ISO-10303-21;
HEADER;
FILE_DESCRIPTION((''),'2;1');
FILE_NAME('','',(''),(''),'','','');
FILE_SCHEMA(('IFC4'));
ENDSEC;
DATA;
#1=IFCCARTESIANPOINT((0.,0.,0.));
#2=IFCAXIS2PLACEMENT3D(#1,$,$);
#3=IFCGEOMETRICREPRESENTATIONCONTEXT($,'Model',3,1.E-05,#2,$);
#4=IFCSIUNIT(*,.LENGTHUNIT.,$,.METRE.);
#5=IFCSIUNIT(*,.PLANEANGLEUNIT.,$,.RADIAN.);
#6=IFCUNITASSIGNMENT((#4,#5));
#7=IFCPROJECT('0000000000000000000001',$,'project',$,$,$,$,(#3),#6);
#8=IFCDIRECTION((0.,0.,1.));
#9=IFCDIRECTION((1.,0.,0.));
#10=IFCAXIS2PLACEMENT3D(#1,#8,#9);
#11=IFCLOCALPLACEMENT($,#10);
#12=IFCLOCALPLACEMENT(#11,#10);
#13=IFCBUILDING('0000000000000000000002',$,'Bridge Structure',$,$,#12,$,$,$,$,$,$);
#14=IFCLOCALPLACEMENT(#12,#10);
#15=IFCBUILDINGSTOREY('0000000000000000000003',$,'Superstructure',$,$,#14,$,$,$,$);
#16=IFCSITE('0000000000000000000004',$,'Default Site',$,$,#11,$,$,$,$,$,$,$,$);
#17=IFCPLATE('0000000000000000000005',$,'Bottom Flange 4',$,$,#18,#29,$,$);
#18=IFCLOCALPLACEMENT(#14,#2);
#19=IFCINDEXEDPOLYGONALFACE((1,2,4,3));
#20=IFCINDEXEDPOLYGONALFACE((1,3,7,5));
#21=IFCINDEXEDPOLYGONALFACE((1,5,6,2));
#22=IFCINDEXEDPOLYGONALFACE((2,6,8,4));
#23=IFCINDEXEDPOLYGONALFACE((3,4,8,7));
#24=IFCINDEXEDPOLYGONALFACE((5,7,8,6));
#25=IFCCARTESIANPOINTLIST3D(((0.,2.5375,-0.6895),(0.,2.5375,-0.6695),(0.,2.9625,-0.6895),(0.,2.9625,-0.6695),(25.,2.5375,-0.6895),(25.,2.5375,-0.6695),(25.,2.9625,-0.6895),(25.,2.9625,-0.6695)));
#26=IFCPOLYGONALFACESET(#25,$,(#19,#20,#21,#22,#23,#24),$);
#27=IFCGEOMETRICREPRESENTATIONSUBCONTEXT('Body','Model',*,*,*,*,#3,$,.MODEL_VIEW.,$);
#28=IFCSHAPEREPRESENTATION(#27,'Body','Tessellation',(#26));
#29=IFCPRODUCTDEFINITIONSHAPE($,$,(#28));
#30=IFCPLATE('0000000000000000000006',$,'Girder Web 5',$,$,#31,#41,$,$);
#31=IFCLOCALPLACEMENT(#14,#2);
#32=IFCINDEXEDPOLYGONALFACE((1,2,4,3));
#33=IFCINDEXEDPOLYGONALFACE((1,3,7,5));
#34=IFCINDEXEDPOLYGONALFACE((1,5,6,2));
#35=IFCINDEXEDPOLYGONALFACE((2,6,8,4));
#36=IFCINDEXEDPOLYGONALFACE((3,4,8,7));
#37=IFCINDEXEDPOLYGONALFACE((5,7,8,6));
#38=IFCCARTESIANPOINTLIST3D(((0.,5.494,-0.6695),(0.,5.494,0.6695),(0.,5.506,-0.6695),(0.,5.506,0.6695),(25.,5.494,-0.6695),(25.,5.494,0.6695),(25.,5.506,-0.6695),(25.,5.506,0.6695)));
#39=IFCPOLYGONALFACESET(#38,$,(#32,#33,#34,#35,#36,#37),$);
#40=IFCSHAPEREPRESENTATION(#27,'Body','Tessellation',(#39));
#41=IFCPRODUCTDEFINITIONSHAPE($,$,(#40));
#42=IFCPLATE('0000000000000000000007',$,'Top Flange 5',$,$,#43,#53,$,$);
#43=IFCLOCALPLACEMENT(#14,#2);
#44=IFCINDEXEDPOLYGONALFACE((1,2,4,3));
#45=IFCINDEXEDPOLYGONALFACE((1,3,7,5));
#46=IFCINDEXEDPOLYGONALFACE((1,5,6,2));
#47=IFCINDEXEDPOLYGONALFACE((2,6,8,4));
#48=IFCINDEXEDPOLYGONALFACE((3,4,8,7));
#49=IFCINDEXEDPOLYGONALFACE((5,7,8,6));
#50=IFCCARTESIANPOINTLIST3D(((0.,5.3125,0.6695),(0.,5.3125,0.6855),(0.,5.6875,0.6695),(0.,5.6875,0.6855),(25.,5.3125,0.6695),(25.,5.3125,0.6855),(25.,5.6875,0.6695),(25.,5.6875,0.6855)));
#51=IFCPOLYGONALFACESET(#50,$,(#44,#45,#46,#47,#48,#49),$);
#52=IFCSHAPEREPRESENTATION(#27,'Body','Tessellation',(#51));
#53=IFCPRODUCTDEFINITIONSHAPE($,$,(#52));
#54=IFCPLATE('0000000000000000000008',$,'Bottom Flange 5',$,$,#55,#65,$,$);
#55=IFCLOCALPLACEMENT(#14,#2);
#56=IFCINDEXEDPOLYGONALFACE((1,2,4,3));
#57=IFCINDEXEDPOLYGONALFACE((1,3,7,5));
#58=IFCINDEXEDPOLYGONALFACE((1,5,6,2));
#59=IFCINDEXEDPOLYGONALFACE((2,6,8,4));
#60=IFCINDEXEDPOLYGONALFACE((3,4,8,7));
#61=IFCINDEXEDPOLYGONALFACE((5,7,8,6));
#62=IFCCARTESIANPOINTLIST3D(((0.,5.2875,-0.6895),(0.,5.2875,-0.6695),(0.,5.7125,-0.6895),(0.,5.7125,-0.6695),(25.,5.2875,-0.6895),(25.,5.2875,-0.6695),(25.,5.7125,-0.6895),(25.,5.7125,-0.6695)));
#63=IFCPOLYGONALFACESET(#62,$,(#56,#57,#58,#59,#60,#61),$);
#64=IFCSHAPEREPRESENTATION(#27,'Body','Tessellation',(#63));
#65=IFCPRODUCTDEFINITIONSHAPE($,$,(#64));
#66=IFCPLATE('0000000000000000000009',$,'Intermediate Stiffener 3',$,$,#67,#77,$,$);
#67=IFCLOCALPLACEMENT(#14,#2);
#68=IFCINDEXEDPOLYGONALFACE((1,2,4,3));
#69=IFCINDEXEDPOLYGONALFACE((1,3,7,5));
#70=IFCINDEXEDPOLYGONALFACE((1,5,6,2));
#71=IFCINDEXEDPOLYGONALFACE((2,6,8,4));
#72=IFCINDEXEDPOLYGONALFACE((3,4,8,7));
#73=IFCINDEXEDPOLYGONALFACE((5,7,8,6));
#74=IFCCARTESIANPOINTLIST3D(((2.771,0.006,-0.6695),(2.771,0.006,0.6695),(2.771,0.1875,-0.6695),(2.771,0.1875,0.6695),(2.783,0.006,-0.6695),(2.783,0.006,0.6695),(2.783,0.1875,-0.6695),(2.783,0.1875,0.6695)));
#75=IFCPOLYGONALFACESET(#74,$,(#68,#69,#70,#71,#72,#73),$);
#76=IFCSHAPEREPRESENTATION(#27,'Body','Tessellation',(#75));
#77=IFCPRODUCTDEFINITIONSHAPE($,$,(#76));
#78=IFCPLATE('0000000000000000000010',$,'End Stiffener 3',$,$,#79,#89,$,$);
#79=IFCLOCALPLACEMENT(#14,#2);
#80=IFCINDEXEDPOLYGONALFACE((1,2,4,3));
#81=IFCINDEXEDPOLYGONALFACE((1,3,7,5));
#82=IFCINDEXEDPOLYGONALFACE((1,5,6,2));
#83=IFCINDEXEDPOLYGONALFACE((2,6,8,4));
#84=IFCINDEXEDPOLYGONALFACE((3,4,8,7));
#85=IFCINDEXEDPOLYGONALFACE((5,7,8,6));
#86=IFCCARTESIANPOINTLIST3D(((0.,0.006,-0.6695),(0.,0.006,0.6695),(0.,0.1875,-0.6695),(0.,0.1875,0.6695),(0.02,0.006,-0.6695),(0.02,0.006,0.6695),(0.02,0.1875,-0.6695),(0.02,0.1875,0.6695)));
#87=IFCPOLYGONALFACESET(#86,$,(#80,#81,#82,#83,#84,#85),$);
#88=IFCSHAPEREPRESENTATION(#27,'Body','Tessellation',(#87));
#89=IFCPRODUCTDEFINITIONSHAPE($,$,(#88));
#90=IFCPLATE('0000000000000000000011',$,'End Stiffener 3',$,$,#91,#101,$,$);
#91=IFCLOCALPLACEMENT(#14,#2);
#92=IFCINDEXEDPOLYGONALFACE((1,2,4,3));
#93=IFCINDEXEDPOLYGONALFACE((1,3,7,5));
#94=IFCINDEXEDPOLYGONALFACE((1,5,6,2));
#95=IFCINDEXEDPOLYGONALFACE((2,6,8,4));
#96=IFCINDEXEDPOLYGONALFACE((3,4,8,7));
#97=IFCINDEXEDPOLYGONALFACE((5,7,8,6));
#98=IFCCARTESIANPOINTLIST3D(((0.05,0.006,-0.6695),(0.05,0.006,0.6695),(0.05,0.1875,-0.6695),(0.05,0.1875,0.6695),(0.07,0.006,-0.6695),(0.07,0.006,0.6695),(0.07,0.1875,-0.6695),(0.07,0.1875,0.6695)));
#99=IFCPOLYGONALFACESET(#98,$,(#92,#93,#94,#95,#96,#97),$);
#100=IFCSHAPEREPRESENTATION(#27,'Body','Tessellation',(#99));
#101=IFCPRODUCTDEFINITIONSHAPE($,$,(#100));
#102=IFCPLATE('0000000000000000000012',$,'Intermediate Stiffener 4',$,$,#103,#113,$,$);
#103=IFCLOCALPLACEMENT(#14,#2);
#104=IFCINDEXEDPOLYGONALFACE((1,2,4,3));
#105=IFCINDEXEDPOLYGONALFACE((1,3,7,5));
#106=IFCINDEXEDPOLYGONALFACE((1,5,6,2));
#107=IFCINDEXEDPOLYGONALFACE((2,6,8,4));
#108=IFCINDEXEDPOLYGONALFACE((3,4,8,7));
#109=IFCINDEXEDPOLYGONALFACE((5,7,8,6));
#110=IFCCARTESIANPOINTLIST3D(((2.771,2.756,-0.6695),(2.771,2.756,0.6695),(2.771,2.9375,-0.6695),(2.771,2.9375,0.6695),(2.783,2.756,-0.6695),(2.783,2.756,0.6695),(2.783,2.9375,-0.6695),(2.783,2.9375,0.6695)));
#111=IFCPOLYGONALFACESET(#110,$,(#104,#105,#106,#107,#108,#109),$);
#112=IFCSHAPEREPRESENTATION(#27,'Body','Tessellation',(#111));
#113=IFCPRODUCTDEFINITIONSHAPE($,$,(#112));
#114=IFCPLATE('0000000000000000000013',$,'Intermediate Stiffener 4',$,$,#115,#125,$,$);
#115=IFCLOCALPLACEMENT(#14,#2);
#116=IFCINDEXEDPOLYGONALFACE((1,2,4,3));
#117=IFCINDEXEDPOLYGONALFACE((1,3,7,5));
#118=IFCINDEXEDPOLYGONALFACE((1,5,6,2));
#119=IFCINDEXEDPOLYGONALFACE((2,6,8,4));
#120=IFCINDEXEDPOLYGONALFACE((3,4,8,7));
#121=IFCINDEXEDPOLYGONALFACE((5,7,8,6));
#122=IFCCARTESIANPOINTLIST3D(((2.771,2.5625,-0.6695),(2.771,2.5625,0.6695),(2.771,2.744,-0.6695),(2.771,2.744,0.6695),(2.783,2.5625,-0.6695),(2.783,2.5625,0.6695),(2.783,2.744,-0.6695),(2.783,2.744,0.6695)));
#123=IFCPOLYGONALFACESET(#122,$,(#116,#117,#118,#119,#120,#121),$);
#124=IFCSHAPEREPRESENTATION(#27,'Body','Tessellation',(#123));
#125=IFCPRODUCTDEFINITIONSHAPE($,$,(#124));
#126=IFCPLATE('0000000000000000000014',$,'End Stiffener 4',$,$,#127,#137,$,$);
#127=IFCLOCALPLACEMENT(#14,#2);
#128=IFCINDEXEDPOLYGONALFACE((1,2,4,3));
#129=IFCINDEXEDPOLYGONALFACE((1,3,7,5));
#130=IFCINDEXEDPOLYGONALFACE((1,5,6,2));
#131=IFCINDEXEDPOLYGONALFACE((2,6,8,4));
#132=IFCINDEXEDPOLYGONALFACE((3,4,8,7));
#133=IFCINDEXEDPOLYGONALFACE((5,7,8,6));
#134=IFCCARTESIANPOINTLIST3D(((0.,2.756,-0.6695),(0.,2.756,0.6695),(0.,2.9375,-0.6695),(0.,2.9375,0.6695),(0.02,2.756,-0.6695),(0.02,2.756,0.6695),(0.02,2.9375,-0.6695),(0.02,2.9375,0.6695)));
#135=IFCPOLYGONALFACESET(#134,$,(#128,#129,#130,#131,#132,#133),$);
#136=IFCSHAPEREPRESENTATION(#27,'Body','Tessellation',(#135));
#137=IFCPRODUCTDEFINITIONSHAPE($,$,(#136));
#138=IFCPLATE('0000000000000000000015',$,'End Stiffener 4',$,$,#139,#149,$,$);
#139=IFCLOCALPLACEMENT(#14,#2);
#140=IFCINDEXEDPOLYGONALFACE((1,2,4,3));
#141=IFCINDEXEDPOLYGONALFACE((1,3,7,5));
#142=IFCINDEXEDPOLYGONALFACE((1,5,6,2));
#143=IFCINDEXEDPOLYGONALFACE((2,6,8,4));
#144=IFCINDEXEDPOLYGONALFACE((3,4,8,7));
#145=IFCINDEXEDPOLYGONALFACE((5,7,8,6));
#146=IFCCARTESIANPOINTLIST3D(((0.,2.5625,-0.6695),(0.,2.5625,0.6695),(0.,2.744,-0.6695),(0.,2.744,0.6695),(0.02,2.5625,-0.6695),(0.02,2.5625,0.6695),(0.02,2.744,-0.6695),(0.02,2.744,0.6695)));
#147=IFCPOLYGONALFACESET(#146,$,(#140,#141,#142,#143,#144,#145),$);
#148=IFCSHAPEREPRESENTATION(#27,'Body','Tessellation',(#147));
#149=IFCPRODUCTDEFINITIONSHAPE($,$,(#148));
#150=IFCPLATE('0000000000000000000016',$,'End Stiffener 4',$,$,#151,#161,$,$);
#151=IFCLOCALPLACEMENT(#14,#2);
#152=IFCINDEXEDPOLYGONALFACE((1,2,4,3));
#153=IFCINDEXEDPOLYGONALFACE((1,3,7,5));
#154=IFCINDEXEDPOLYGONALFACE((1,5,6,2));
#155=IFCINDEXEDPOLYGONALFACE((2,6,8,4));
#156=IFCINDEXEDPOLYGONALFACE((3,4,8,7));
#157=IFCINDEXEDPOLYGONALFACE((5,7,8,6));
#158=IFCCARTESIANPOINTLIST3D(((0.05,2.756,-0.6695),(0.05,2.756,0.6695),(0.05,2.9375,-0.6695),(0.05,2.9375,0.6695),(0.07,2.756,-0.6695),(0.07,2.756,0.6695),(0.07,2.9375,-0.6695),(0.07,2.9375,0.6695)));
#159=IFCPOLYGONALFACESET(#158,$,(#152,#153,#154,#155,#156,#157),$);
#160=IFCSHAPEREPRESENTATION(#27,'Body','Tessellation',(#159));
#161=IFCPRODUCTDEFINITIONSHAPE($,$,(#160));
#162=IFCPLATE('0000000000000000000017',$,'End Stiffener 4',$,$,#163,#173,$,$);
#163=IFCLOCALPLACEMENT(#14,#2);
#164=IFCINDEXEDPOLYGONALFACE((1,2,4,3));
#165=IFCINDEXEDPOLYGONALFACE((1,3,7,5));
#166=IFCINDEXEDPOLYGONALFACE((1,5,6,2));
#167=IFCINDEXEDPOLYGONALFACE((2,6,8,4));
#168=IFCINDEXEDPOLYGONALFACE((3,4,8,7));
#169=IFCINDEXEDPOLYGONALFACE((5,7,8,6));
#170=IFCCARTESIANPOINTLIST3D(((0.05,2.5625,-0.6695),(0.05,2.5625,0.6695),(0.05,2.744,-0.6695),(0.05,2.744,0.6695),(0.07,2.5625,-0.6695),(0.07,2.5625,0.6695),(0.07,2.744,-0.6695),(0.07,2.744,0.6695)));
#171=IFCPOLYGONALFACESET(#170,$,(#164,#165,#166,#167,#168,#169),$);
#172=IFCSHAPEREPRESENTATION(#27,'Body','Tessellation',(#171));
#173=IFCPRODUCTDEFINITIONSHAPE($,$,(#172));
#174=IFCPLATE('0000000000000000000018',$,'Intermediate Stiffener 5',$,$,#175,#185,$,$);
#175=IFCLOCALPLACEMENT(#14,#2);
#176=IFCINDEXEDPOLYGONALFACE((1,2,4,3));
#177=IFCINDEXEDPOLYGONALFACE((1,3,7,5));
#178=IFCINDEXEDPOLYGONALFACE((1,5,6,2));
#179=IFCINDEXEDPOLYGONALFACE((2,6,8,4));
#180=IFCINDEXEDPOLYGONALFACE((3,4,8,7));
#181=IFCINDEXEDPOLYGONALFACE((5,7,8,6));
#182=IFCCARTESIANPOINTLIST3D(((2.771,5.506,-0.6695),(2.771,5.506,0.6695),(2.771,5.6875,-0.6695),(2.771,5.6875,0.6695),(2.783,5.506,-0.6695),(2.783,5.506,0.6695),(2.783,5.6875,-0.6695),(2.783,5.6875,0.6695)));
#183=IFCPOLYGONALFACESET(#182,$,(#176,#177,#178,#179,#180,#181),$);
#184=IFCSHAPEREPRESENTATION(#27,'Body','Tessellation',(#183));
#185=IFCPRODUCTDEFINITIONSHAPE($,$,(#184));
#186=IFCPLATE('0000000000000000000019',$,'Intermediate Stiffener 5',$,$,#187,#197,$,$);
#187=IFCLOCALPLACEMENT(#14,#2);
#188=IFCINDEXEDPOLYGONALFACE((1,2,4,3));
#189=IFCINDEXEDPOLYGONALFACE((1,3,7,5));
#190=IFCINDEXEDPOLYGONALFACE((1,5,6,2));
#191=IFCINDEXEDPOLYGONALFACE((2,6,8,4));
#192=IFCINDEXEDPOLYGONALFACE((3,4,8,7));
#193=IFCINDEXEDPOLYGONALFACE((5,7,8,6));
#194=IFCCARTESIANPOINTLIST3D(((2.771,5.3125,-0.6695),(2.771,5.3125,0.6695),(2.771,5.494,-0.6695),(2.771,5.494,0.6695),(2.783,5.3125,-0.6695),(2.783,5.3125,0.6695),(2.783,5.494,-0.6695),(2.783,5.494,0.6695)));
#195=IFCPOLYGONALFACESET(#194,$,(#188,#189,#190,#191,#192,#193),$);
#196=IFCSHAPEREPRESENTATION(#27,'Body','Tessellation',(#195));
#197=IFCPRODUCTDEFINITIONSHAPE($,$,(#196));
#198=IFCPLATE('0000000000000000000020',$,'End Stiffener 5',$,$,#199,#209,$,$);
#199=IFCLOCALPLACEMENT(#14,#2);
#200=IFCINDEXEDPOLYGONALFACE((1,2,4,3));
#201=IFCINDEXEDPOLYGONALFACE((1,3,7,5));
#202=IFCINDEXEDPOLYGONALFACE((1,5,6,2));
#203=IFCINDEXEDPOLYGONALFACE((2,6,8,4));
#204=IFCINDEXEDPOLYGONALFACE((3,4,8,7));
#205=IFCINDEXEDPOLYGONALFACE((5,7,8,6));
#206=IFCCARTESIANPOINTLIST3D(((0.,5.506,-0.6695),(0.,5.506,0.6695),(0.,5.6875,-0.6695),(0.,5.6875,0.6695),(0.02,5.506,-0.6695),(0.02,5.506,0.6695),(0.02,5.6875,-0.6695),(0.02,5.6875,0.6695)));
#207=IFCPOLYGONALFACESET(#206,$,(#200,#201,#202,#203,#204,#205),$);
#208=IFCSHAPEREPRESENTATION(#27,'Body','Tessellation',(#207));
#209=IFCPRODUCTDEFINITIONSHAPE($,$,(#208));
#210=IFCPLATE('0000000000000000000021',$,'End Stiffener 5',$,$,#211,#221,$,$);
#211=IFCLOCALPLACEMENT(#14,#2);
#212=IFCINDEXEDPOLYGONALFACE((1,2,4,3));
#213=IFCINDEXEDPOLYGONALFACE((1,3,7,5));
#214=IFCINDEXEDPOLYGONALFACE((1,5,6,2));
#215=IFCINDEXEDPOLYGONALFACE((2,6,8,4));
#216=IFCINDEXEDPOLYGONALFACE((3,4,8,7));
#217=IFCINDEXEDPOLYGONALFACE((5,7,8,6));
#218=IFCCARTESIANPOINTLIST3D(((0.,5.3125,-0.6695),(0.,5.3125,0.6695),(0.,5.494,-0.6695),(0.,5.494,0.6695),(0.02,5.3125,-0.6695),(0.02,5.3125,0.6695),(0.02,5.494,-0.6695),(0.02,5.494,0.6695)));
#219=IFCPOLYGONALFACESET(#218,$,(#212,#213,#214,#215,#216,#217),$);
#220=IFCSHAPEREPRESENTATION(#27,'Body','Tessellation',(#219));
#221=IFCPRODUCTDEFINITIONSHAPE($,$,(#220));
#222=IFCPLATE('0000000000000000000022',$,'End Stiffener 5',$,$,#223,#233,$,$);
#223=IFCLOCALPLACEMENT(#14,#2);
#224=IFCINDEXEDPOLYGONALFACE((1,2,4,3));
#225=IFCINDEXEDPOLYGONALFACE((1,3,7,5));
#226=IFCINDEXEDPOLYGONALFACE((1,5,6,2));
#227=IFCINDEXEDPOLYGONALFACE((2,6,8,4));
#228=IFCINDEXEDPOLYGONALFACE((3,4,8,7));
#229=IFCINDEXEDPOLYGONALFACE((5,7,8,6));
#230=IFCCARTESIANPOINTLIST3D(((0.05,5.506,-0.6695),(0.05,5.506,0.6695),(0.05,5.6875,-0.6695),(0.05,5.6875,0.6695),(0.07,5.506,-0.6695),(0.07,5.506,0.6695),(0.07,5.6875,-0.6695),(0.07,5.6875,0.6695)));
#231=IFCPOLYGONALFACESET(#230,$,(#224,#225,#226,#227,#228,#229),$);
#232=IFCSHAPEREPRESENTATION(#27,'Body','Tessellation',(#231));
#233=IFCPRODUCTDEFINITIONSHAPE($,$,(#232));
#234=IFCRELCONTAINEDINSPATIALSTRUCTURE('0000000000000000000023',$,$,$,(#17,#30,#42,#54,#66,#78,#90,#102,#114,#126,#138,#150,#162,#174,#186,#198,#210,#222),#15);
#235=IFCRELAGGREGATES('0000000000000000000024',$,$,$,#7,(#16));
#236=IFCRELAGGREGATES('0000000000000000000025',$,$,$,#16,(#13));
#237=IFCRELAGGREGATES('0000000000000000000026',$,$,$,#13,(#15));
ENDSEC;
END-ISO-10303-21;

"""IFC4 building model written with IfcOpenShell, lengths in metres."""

from ifc_helpers import new_model, si_unit, frame, origin, origin_with_axes, origin_2d_with_axis, place, context, subcontext, project, spatial, rectangle, extrude, element, save


model = new_model("IFC4")

# Units and contexts
model_context = context("Model", 3, precision=1e-05, world=origin())
body_context = subcontext(model_context, "Body", "Model", "MODEL_VIEW")
ifc_project = project(units=[si_unit("LENGTHUNIT", "METRE"), si_unit("PLANEANGLEUNIT", "RADIAN")], contexts=[model_context])

# Site, building, storey
site_placement = place(None, origin_with_axes())
site = spatial("IfcSite", under=ifc_project, at=site_placement, Name="Default Site")
building_placement = place(site_placement, origin_with_axes())
building = spatial("IfcBuilding", under=site, at=building_placement, Name="Bridge Structure")
storey_placement = place(building_placement, origin_with_axes())
storey = spatial("IfcBuildingStorey", under=building, at=storey_placement, Name="Superstructure")

# Plates
plate_1_placement = place(storey_placement, frame((0.0, 2.75, -0.6795), z_axis=(1.0, 0.0, 0.0), x_axis=(0.0, 1.0, 0.0)))
element("IfcPlate", 1, at=plate_1_placement, inside=storey, Name="Bottom Flange 4", context=body_context, shape_type="SweptSolid", body=[
    extrude(rectangle(XDim=0.425, YDim=0.02, at=origin_2d_with_axis()), origin_with_axes(), (0.0, 0.0, 1.0), 25.0),
])
plate_2_placement = place(storey_placement, frame((0.0, 5.5, 0.0), z_axis=(1.0, 0.0, 0.0), x_axis=(0.0, 1.0, 0.0)))
element("IfcPlate", 2, at=plate_2_placement, inside=storey, Name="Girder Web 5", context=body_context, shape_type="SweptSolid", body=[
    extrude(rectangle(XDim=0.012, YDim=1.339, at=origin_2d_with_axis()), origin_with_axes(), (0.0, 0.0, 1.0), 25.0),
])
plate_3_placement = place(storey_placement, frame((0.0, 5.5, 0.6775), z_axis=(1.0, 0.0, 0.0), x_axis=(0.0, 1.0, 0.0)))
element("IfcPlate", 3, at=plate_3_placement, inside=storey, Name="Top Flange 5", context=body_context, shape_type="SweptSolid", body=[
    extrude(rectangle(XDim=0.375, YDim=0.016, at=origin_2d_with_axis()), origin_with_axes(), (0.0, 0.0, 1.0), 25.0),
])
plate_4_placement = place(storey_placement, frame((0.0, 5.5, -0.6795), z_axis=(1.0, 0.0, 0.0), x_axis=(0.0, 1.0, 0.0)))
element("IfcPlate", 4, at=plate_4_placement, inside=storey, Name="Bottom Flange 5", context=body_context, shape_type="SweptSolid", body=[
    extrude(rectangle(XDim=0.425, YDim=0.02, at=origin_2d_with_axis()), origin_with_axes(), (0.0, 0.0, 1.0), 25.0),
])
plate_5_placement = place(storey_placement, frame((2.777, 0.0968, -0.6695), z_axis=(0.0, 0.0, 1.0), x_axis=(1.0, 0.0, 0.0)))
element("IfcPlate", 5, at=plate_5_placement, inside=storey, Name="Intermediate Stiffener 3", context=body_context, shape_type="SweptSolid", body=[
    extrude(rectangle(XDim=0.012, YDim=0.1815, at=origin_2d_with_axis()), origin_with_axes(), (0.0, 0.0, 1.0), 1.339),
])
for number, where, z_axis, x_axis, name in (
    (6, (0.01, 0.0968, -0.6695), (0.0, 0.0, 1.0), (1.0, 0.0, 0.0), "End Stiffener 3"),
    (7, (0.06, 0.0968, -0.6695), (0.0, 0.0, 1.0), (1.0, 0.0, 0.0), "End Stiffener 3"),
):
    element("IfcPlate", number, at=place(storey_placement, frame(where, z_axis=z_axis, x_axis=x_axis)), inside=storey, Name=name, context=body_context, shape_type="SweptSolid", body=[
        extrude(rectangle(XDim=0.02, YDim=0.1815, at=origin_2d_with_axis()), origin_with_axes(), (0.0, 0.0, 1.0), 1.339),
    ])
for number, where, z_axis, x_axis, name in (
    (8, (2.777, 2.8468, -0.6695), (0.0, 0.0, 1.0), (1.0, 0.0, 0.0), "Intermediate Stiffener 4"),
    (9, (2.777, 2.6532, -0.6695), (0.0, 0.0, 1.0), (1.0, 0.0, 0.0), "Intermediate Stiffener 4"),
):
    element("IfcPlate", number, at=place(storey_placement, frame(where, z_axis=z_axis, x_axis=x_axis)), inside=storey, Name=name, context=body_context, shape_type="SweptSolid", body=[
        extrude(rectangle(XDim=0.012, YDim=0.1815, at=origin_2d_with_axis()), origin_with_axes(), (0.0, 0.0, 1.0), 1.339),
    ])
for number, where, z_axis, x_axis, name in (
    (10, (0.01, 2.8468, -0.6695), (0.0, 0.0, 1.0), (1.0, 0.0, 0.0), "End Stiffener 4"),
    (11, (0.01, 2.6532, -0.6695), (0.0, 0.0, 1.0), (1.0, 0.0, 0.0), "End Stiffener 4"),
    (12, (0.06, 2.8468, -0.6695), (0.0, 0.0, 1.0), (1.0, 0.0, 0.0), "End Stiffener 4"),
    (13, (0.06, 2.6532, -0.6695), (0.0, 0.0, 1.0), (1.0, 0.0, 0.0), "End Stiffener 4"),
):
    element("IfcPlate", number, at=place(storey_placement, frame(where, z_axis=z_axis, x_axis=x_axis)), inside=storey, Name=name, context=body_context, shape_type="SweptSolid", body=[
        extrude(rectangle(XDim=0.02, YDim=0.1815, at=origin_2d_with_axis()), origin_with_axes(), (0.0, 0.0, 1.0), 1.339),
    ])
for number, where, z_axis, x_axis, name in (
    (14, (2.777, 5.5968, -0.6695), (0.0, 0.0, 1.0), (1.0, 0.0, 0.0), "Intermediate Stiffener 5"),
    (15, (2.777, 5.4032, -0.6695), (0.0, 0.0, 1.0), (1.0, 0.0, 0.0), "Intermediate Stiffener 5"),
):
    element("IfcPlate", number, at=place(storey_placement, frame(where, z_axis=z_axis, x_axis=x_axis)), inside=storey, Name=name, context=body_context, shape_type="SweptSolid", body=[
        extrude(rectangle(XDim=0.012, YDim=0.1815, at=origin_2d_with_axis()), origin_with_axes(), (0.0, 0.0, 1.0), 1.339),
    ])
for number, where, z_axis, x_axis, name in (
    (16, (0.01, 5.5968, -0.6695), (0.0, 0.0, 1.0), (1.0, 0.0, 0.0), "End Stiffener 5"),
    (17, (0.01, 5.4032, -0.6695), (0.0, 0.0, 1.0), (1.0, 0.0, 0.0), "End Stiffener 5"),
    (18, (0.06, 5.5968, -0.6695), (0.0, 0.0, 1.0), (1.0, 0.0, 0.0), "End Stiffener 5"),
):
    element("IfcPlate", number, at=place(storey_placement, frame(where, z_axis=z_axis, x_axis=x_axis)), inside=storey, Name=name, context=body_context, shape_type="SweptSolid", body=[
        extrude(rectangle(XDim=0.02, YDim=0.1815, at=origin_2d_with_axis()), origin_with_axes(), (0.0, 0.0, 1.0), 1.339),
    ])

save(model, "model.ifc")
